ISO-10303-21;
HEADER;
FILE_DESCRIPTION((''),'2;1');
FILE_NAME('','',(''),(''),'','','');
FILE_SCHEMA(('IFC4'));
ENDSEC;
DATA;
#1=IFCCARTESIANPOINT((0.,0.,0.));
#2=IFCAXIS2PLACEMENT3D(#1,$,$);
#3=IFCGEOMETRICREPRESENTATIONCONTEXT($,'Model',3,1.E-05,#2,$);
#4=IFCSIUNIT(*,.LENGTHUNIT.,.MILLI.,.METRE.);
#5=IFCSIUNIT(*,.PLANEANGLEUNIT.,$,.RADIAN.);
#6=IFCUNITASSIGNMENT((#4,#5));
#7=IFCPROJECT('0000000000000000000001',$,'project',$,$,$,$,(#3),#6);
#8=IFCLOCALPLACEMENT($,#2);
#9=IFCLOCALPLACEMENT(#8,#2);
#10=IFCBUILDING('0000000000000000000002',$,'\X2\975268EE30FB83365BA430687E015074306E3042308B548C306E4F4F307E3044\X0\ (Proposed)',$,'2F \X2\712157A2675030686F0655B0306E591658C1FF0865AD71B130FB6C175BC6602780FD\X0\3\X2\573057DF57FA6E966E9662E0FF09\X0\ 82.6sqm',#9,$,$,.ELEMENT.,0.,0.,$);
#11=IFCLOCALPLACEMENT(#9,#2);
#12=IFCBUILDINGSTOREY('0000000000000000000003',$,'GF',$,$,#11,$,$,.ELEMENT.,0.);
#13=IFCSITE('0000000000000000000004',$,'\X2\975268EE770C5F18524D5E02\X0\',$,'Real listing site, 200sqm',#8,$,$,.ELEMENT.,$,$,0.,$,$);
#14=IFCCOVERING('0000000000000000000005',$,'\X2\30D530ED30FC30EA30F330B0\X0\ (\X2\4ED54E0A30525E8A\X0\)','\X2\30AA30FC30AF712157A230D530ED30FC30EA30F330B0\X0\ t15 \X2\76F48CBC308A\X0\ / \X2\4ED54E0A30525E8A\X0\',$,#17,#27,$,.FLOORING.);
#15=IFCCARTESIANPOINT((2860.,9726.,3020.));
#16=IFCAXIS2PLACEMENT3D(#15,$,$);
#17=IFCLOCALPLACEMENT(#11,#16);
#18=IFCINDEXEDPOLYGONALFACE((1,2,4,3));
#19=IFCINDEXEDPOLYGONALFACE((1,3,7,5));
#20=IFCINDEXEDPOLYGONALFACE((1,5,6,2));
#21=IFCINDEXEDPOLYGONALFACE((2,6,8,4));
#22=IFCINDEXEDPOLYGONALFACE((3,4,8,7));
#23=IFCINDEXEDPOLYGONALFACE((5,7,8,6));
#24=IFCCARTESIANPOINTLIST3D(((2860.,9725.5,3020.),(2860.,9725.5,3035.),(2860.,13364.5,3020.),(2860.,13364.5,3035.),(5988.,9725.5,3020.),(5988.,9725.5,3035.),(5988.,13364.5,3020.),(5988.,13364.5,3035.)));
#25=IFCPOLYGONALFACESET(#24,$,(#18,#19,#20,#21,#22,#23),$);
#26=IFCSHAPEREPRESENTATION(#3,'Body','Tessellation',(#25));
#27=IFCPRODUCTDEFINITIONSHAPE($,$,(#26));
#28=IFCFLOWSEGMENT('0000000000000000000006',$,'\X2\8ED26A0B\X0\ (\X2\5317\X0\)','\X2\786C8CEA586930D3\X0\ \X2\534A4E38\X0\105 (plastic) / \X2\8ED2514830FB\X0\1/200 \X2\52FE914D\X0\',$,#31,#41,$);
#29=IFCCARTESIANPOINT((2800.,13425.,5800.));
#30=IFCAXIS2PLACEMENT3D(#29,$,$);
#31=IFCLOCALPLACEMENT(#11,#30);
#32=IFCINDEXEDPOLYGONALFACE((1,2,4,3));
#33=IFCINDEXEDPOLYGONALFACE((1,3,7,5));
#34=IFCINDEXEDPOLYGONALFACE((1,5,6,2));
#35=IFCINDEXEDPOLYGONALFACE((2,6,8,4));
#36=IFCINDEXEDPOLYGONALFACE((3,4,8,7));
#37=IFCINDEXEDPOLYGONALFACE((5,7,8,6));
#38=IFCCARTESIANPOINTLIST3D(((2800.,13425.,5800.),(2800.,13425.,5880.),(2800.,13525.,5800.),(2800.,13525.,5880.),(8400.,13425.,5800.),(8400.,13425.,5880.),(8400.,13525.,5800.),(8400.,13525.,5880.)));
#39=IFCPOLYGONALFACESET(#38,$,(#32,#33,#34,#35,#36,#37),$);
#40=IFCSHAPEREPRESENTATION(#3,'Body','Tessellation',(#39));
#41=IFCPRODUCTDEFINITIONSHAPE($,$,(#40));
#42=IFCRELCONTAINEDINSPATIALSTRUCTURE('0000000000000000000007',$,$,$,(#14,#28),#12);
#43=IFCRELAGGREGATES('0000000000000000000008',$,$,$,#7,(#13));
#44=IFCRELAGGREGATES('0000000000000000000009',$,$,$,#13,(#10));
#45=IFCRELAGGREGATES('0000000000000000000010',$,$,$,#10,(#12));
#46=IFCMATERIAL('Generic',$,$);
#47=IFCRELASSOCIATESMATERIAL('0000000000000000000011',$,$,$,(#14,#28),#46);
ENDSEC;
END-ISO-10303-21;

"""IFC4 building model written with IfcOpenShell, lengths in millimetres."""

from ifc_helpers import new_model, si_unit, frame, frame_2d, origin, place, context, project, spatial, rectangle, extrude, material, element, save


model = new_model("IFC4")

# Units and contexts
model_context = context("Model", 3, precision=1e-05, world=origin())
ifc_project = project(units=[si_unit("LENGTHUNIT", "METRE", prefix="MILLI"), si_unit("PLANEANGLEUNIT", "RADIAN")], contexts=[model_context])

# Site, building, storey
site_placement = place(None, origin())
site = spatial("IfcSite", under=ifc_project, at=site_placement, Name="青森県弘前市", ObjectType="Real listing site, 200sqm", CompositionType="ELEMENT", RefElevation=0.0)
building_placement = place(site_placement, origin())
building = spatial("IfcBuilding", under=site, at=building_placement, Name="青森・茶室と縁側のある和の住まい (Proposed)", ObjectType="2F 無垢材と漆喰の外壁（断熱・気密性能3地域基準準拠） 82.6sqm", CompositionType="ELEMENT", ElevationOfRefHeight=0.0, ElevationOfTerrain=0.0)
storey_placement = place(building_placement, origin())
storey = spatial("IfcBuildingStorey", under=building, at=storey_placement, Name="GF", CompositionType="ELEMENT", Elevation=0.0)

# Covering
ifc_material_1 = material(Name="Generic")
covering_placement = place(storey_placement, frame((2860.0, 9726.0, 3020.0)))
element("IfcCovering", 1, at=covering_placement, inside=storey, material=ifc_material_1, Name="フローリング (仕上げ床)", Description="オーク無垢フローリング t15 直貼り / 仕上げ床", PredefinedType="FLOORING", context=model_context, shape_type="SweptSolid", body=[
    extrude(rectangle(XDim=3128.0, YDim=3639.0, at=frame_2d((1564.0, 1819.0))), frame((2860.0, 9726.0, 3020.0)), (0.0, 0.0, 1.0), 15.0),
])

# Flow segment
flow_segment_placement = place(storey_placement, frame((2800.0, 13425.0, 5800.0)))
element("IfcFlowSegment", 2, at=flow_segment_placement, inside=storey, material=ifc_material_1, Name="軒樋 (北)", Description="硬質塩ビ 半丸105 (plastic) / 軒先・1/200 勾配", context=model_context, shape_type="SweptSolid", body=[
    extrude(rectangle(XDim=5600.0, YDim=100.0, at=frame_2d((2800.0, 50.0))), frame((2800.0, 13425.0, 5800.0)), (0.0, 0.0, 1.0), 80.0),
])

save(model, "model.ifc")
